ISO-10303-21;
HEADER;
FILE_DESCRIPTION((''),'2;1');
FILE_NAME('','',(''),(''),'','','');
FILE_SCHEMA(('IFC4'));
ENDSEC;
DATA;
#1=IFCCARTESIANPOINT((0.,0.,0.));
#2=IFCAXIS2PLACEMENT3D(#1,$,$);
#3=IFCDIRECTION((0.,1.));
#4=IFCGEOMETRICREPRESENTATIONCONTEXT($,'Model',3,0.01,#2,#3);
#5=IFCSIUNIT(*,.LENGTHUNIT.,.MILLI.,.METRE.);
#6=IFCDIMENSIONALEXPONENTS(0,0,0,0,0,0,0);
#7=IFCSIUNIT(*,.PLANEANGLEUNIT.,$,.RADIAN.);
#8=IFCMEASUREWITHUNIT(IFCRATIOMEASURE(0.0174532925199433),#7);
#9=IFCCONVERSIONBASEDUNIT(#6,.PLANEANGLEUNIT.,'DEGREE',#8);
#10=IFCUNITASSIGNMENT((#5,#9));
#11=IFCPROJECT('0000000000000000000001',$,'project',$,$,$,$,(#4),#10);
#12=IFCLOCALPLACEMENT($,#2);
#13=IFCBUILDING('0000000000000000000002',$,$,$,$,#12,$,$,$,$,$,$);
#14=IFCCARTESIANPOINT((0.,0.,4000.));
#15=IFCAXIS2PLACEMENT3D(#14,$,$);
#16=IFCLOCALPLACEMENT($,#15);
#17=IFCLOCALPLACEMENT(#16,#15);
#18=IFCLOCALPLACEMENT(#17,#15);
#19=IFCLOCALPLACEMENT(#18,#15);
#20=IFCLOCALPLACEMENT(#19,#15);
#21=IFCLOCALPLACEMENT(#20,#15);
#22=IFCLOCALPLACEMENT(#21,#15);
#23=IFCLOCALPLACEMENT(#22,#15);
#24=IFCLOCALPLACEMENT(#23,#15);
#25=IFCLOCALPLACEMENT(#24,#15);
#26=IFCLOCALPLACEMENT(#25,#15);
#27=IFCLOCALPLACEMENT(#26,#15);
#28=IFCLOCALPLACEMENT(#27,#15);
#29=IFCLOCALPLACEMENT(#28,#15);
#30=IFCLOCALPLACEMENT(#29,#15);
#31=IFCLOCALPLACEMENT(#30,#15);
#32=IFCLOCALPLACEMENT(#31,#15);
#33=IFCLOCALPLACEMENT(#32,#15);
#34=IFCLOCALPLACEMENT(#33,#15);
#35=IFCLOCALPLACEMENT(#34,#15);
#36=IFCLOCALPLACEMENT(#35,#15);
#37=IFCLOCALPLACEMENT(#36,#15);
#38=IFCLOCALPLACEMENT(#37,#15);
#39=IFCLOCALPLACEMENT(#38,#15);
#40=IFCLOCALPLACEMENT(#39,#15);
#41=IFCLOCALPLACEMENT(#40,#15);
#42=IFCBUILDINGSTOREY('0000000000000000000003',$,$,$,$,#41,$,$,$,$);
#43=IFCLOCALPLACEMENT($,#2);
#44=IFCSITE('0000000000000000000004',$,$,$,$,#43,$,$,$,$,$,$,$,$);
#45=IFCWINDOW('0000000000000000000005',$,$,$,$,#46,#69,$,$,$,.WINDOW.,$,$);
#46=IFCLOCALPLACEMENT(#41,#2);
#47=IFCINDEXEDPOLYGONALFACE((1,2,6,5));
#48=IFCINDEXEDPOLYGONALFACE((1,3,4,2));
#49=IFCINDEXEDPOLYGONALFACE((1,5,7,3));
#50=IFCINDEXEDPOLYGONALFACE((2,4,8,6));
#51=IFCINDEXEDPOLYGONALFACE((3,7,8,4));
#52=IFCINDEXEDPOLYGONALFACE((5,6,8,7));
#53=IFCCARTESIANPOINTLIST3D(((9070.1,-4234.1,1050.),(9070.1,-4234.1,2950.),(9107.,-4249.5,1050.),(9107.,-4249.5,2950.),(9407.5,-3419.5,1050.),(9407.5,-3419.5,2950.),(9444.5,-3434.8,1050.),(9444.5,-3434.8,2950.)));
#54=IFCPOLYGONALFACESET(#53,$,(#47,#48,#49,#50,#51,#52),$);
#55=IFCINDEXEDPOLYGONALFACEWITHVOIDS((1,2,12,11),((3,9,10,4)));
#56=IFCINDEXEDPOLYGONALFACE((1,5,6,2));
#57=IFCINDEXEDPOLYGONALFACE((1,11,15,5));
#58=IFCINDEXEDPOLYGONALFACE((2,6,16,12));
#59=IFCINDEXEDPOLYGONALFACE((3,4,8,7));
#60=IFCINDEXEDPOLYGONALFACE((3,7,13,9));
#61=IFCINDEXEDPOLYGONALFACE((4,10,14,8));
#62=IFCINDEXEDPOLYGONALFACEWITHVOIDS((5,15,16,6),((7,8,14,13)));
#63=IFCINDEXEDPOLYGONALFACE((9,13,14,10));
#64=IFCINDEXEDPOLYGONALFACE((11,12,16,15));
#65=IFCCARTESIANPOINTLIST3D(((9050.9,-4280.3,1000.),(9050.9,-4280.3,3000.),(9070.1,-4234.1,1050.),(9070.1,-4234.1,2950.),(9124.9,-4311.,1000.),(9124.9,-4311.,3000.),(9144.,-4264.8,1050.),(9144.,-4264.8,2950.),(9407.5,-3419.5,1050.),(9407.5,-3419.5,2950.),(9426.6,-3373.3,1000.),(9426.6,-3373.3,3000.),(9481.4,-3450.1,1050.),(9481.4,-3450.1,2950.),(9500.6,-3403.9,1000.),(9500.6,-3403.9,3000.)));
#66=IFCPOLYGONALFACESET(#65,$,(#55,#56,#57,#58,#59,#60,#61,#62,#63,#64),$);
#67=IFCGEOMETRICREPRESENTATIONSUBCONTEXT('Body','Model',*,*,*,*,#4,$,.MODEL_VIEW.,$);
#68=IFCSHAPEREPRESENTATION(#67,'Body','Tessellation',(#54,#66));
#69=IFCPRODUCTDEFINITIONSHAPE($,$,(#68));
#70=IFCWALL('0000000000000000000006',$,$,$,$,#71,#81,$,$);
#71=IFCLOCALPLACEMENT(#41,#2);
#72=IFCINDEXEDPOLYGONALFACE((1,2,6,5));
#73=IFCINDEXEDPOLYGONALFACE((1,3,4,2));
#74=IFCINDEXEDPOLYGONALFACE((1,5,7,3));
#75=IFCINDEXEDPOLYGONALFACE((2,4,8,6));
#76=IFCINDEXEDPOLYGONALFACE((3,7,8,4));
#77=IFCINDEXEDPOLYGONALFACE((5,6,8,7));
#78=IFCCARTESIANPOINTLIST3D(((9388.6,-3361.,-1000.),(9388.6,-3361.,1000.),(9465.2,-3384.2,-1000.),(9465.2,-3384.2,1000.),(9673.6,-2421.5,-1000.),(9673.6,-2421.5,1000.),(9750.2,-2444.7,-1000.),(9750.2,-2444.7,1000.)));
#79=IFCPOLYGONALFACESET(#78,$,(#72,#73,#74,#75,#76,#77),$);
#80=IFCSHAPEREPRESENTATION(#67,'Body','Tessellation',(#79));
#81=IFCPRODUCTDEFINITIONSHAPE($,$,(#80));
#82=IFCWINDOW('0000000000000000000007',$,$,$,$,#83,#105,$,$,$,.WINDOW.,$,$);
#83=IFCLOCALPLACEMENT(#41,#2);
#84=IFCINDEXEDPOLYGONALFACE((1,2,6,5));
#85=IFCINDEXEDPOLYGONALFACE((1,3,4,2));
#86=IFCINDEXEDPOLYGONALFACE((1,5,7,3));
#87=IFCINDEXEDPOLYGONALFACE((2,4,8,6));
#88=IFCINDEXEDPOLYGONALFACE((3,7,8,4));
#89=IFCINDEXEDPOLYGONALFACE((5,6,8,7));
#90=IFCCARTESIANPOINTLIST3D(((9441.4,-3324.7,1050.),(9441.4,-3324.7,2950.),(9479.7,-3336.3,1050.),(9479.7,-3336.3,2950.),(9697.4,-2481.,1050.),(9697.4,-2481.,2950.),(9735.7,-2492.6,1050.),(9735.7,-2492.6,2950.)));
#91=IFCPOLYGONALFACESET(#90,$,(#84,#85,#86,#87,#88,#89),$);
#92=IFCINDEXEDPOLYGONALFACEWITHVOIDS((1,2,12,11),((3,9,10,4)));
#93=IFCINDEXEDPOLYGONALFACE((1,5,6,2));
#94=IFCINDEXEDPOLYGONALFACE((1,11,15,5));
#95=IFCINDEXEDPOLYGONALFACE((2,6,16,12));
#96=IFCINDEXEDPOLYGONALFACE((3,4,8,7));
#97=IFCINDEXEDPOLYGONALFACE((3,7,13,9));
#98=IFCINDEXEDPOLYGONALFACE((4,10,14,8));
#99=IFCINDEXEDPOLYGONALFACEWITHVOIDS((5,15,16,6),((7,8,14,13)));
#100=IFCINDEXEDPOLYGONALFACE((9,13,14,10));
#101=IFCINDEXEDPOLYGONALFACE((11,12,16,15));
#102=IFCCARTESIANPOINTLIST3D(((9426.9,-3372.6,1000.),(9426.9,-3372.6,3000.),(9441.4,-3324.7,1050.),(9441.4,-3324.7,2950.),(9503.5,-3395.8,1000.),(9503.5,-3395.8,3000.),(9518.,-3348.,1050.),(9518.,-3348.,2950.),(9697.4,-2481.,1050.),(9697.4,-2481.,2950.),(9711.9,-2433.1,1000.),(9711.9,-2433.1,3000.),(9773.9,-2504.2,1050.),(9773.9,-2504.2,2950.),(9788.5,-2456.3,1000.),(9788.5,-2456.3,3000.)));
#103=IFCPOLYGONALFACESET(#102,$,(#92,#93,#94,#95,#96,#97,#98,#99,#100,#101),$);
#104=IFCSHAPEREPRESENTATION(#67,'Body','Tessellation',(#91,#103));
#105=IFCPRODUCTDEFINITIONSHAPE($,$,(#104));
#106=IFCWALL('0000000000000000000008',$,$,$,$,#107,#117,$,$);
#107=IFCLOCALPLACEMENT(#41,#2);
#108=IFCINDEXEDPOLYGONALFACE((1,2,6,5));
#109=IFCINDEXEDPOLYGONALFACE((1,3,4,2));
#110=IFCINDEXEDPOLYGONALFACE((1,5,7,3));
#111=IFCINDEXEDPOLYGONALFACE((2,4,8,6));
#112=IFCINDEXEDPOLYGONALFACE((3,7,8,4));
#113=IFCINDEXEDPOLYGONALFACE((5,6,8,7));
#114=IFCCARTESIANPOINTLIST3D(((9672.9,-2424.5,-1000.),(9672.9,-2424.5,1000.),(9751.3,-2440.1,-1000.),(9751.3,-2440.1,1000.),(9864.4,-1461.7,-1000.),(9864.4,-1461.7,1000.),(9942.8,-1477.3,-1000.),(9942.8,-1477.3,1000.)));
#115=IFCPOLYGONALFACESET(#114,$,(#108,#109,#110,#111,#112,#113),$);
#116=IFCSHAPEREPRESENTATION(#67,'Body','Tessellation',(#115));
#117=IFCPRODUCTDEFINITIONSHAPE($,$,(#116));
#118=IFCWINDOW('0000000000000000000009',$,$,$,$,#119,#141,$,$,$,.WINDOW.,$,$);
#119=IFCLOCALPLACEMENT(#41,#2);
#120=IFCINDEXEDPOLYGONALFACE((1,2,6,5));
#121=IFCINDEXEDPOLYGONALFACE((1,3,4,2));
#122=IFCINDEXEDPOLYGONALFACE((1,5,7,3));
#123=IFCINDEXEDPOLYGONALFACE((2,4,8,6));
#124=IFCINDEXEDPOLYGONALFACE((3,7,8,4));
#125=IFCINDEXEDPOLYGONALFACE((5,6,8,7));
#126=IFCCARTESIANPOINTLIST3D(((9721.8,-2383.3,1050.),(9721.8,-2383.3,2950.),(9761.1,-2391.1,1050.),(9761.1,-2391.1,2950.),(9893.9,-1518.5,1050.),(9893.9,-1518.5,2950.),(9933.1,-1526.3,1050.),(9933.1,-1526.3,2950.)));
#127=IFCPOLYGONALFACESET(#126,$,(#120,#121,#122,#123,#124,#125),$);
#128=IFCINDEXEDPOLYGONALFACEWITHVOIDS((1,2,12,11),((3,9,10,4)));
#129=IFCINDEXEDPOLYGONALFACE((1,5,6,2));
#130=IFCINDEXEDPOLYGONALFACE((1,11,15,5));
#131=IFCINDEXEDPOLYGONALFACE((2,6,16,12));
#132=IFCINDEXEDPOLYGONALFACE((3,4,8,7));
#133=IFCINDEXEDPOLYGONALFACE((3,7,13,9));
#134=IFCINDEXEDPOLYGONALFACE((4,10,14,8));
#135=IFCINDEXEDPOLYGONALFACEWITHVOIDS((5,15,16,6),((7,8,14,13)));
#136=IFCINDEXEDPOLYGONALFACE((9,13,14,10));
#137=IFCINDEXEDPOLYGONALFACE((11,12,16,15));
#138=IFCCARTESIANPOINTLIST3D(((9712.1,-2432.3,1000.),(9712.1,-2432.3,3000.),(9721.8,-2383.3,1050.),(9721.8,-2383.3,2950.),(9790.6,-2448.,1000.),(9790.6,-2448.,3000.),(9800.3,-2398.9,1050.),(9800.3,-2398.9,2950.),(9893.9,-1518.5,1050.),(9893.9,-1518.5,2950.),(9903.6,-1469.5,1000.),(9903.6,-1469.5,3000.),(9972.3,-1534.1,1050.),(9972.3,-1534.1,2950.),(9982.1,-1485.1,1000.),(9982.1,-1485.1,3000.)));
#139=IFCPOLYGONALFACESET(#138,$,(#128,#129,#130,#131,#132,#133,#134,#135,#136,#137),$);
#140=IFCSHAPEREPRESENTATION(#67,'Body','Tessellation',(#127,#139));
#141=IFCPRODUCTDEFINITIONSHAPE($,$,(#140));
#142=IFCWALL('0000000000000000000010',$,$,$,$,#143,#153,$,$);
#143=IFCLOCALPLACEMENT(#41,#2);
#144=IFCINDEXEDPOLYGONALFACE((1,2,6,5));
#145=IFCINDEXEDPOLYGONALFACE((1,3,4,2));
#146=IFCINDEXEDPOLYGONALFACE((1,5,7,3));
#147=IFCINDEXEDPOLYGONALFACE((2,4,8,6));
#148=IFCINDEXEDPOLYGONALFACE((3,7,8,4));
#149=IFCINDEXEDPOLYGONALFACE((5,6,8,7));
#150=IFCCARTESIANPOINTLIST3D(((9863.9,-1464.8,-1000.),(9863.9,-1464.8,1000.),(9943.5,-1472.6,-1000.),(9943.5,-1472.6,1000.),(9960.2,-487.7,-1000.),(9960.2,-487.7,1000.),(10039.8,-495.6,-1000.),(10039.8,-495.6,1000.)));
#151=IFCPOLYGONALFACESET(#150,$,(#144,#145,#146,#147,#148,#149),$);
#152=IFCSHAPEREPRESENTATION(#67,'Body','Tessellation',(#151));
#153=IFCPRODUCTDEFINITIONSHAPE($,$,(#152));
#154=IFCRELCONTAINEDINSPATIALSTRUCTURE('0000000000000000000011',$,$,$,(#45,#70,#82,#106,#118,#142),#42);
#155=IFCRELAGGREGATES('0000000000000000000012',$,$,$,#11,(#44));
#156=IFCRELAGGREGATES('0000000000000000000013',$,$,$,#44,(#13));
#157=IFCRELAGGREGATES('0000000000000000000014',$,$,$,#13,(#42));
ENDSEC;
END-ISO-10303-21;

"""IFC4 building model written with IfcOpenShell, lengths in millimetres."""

from ifc_helpers import new_model, entity, si_unit, converted_unit, direction, frame, origin, origin_2d, place, context, subcontext, project, spatial, rectangle, extrude, element, save


model = new_model("IFC4")

# Units and contexts
model_context = context("Model", 3, precision=0.01, world=origin(), true_north=direction((0.0, 1.0)))
body_context = subcontext(model_context, "Body", "Model", "MODEL_VIEW")
ifc_project = project(units=[si_unit("LENGTHUNIT", "METRE", prefix="MILLI"), converted_unit("PLANEANGLEUNIT", "DEGREE", entity("IfcRatioMeasure", 0.0174532925199433), si_unit("PLANEANGLEUNIT", "RADIAN"), dimensions=[0, 0, 0, 0, 0, 0, 0])], contexts=[model_context])

# Site, building, storey
site_placement = place(None, origin())
site = spatial("IfcSite", under=ifc_project, at=site_placement)
building_placement = place(None, origin())
building = spatial("IfcBuilding", under=site, at=building_placement)
placement_1 = place(None, frame((0.0, 0.0, 4000.0)))
placement_2 = place(placement_1, frame((0.0, 0.0, 4000.0)))
placement_3 = place(placement_2, frame((0.0, 0.0, 4000.0)))
placement_4 = place(placement_3, frame((0.0, 0.0, 4000.0)))
placement_5 = place(placement_4, frame((0.0, 0.0, 4000.0)))
placement_6 = place(placement_5, frame((0.0, 0.0, 4000.0)))
placement_7 = place(placement_6, frame((0.0, 0.0, 4000.0)))
placement_8 = place(placement_7, frame((0.0, 0.0, 4000.0)))
placement_9 = place(placement_8, frame((0.0, 0.0, 4000.0)))
placement_10 = place(placement_9, frame((0.0, 0.0, 4000.0)))
placement_11 = place(placement_10, frame((0.0, 0.0, 4000.0)))
placement_12 = place(placement_11, frame((0.0, 0.0, 4000.0)))
placement_13 = place(placement_12, frame((0.0, 0.0, 4000.0)))
placement_14 = place(placement_13, frame((0.0, 0.0, 4000.0)))
placement_15 = place(placement_14, frame((0.0, 0.0, 4000.0)))
placement_16 = place(placement_15, frame((0.0, 0.0, 4000.0)))
placement_17 = place(placement_16, frame((0.0, 0.0, 4000.0)))
placement_18 = place(placement_17, frame((0.0, 0.0, 4000.0)))
placement_19 = place(placement_18, frame((0.0, 0.0, 4000.0)))
placement_20 = place(placement_19, frame((0.0, 0.0, 4000.0)))
placement_21 = place(placement_20, frame((0.0, 0.0, 4000.0)))
placement_22 = place(placement_21, frame((0.0, 0.0, 4000.0)))
placement_23 = place(placement_22, frame((0.0, 0.0, 4000.0)))
placement_24 = place(placement_23, frame((0.0, 0.0, 4000.0)))
placement_25 = place(placement_24, frame((0.0, 0.0, 4000.0)))
storey_placement = place(placement_25, frame((0.0, 0.0, 4000.0)))
storey = spatial("IfcBuildingStorey", under=building, at=storey_placement)

# Shared definitions
cartesian_point_1 = entity("IfcCartesianPoint", [-440.9, -950.0])
shared_polyline = entity("IfcPolyline", [cartesian_point_1, entity("IfcCartesianPoint", [-440.9, 950.0]), entity("IfcCartesianPoint", [-440.9, 950.0]), entity("IfcCartesianPoint", [440.9, 950.0]), entity("IfcCartesianPoint", [440.9, 950.0]), entity("IfcCartesianPoint", [440.9, -950.0]), entity("IfcCartesianPoint", [440.9, -950.0]), entity("IfcCartesianPoint", [-440.9, -950.0]), cartesian_point_1])

# Window
window_1_placement = place(storey_placement, frame((9238.8, -3826.8, 2000.0), z_axis=(0.0, 0.0, 1.0), x_axis=(3826.834186, 9238.795382, 0.0)))
cartesian_point_2 = entity("IfcCartesianPoint", [-490.9, -1000.0])
element("IfcWindow", 1, at=window_1_placement, inside=storey, PredefinedType="WINDOW", context=body_context, shape_type="SweptSolid", body=[
    entity("IfcExtrudedAreaSolid", entity("IfcArbitraryClosedProfileDef", "AREA", None, shared_polyline), entity("IfcAxis2Placement3D", entity("IfcCartesianPoint", [0.0, 0.0, 0.0]), entity("IfcDirection", [0.0, -1.0, 0.0]), entity("IfcDirection", [1.0, 0.0, 0.0])), entity("IfcDirection", [0.0, 0.0, 1.0]), 40.0),
    entity("IfcExtrudedAreaSolid", entity("IfcArbitraryProfileDefWithVoids", "AREA", None, entity("IfcPolyline", [cartesian_point_2, entity("IfcCartesianPoint", [-490.9, 1000.0]), entity("IfcCartesianPoint", [-490.9, 1000.0]), entity("IfcCartesianPoint", [490.9, 1000.0]), entity("IfcCartesianPoint", [490.9, 1000.0]), entity("IfcCartesianPoint", [490.9, -1000.0]), entity("IfcCartesianPoint", [490.9, -1000.0]), entity("IfcCartesianPoint", [-490.9, -1000.0]), cartesian_point_2]), [shared_polyline]), entity("IfcAxis2Placement3D", entity("IfcCartesianPoint", [0.0, 0.0, 0.0]), entity("IfcDirection", [0.0, -1.0, 0.0]), entity("IfcDirection", [1.0, 0.0, 0.0])), entity("IfcDirection", [0.0, 0.0, 1.0]), 80.0),
])

# Wall
wall_1_placement = place(storey_placement, frame((9569.4, -2902.8, -1000.0), z_axis=(0.0, 0.0, 1.0), x_axis=(2902.848529, 9569.402825, 0.0)))
element("IfcWall", 2, at=wall_1_placement, inside=storey, context=body_context, shape_type="SweptSolid", body=[
    extrude(rectangle(XDim=981.7, YDim=80.0, at=origin_2d()), origin(), (0.0, 0.0, 1.0), 2000.0),
])

# Window
window_2_placement = place(storey_placement, frame((9569.4, -2902.8, 2000.0), z_axis=(0.0, 0.0, 1.0), x_axis=(2902.848529, 9569.402825, 0.0)))
cartesian_point_3 = entity("IfcCartesianPoint", [-490.9, -1000.0])
element("IfcWindow", 3, at=window_2_placement, inside=storey, PredefinedType="WINDOW", context=body_context, shape_type="SweptSolid", body=[
    entity("IfcExtrudedAreaSolid", entity("IfcArbitraryClosedProfileDef", "AREA", None, shared_polyline), entity("IfcAxis2Placement3D", entity("IfcCartesianPoint", [0.0, 0.0, 0.0]), entity("IfcDirection", [0.0, -1.0, 0.0]), entity("IfcDirection", [1.0, 0.0, 0.0])), entity("IfcDirection", [0.0, 0.0, 1.0]), 40.0),
    entity("IfcExtrudedAreaSolid", entity("IfcArbitraryProfileDefWithVoids", "AREA", None, entity("IfcPolyline", [cartesian_point_3, entity("IfcCartesianPoint", [-490.9, 1000.0]), entity("IfcCartesianPoint", [-490.9, 1000.0]), entity("IfcCartesianPoint", [490.9, 1000.0]), entity("IfcCartesianPoint", [490.9, 1000.0]), entity("IfcCartesianPoint", [490.9, -1000.0]), entity("IfcCartesianPoint", [490.9, -1000.0]), entity("IfcCartesianPoint", [-490.9, -1000.0]), cartesian_point_3]), [shared_polyline]), entity("IfcAxis2Placement3D", entity("IfcCartesianPoint", [0.0, 0.0, 0.0]), entity("IfcDirection", [0.0, -1.0, 0.0]), entity("IfcDirection", [1.0, 0.0, 0.0])), entity("IfcDirection", [0.0, 0.0, 1.0]), 80.0),
])

# Wall
wall_2_placement = place(storey_placement, frame((9807.9, -1950.9, -1000.0), z_axis=(0.0, 0.0, 1.0), x_axis=(1950.90229, 9807.852989, 0.0)))
element("IfcWall", 4, at=wall_2_placement, inside=storey, context=body_context, shape_type="SweptSolid", body=[
    extrude(rectangle(XDim=981.7, YDim=80.0, at=origin_2d()), origin(), (0.0, 0.0, 1.0), 2000.0),
])

# Window
window_3_placement = place(storey_placement, frame((9807.9, -1950.9, 2000.0), z_axis=(0.0, 0.0, 1.0), x_axis=(1950.90229, 9807.852989, 0.0)))
cartesian_point_4 = entity("IfcCartesianPoint", [-490.9, -1000.0])
element("IfcWindow", 5, at=window_3_placement, inside=storey, PredefinedType="WINDOW", context=body_context, shape_type="SweptSolid", body=[
    entity("IfcExtrudedAreaSolid", entity("IfcArbitraryClosedProfileDef", "AREA", None, shared_polyline), entity("IfcAxis2Placement3D", entity("IfcCartesianPoint", [0.0, 0.0, 0.0]), entity("IfcDirection", [0.0, -1.0, 0.0]), entity("IfcDirection", [1.0, 0.0, 0.0])), entity("IfcDirection", [0.0, 0.0, 1.0]), 40.0),
    entity("IfcExtrudedAreaSolid", entity("IfcArbitraryProfileDefWithVoids", "AREA", None, entity("IfcPolyline", [cartesian_point_4, entity("IfcCartesianPoint", [-490.9, 1000.0]), entity("IfcCartesianPoint", [-490.9, 1000.0]), entity("IfcCartesianPoint", [490.9, 1000.0]), entity("IfcCartesianPoint", [490.9, 1000.0]), entity("IfcCartesianPoint", [490.9, -1000.0]), entity("IfcCartesianPoint", [490.9, -1000.0]), entity("IfcCartesianPoint", [-490.9, -1000.0]), cartesian_point_4]), [shared_polyline]), entity("IfcAxis2Placement3D", entity("IfcCartesianPoint", [0.0, 0.0, 0.0]), entity("IfcDirection", [0.0, -1.0, 0.0]), entity("IfcDirection", [1.0, 0.0, 0.0])), entity("IfcDirection", [0.0, 0.0, 1.0]), 80.0),
])

# Wall
wall_3_placement = place(storey_placement, frame((9951.8, -980.2, -1000.0), z_axis=(0.0, 0.0, 1.0), x_axis=(980.172434, 9951.847165, 0.0)))
element("IfcWall", 6, at=wall_3_placement, inside=storey, context=body_context, shape_type="SweptSolid", body=[
    extrude(rectangle(XDim=981.7, YDim=80.0, at=origin_2d()), origin(), (0.0, 0.0, 1.0), 2000.0),
])

save(model, "model.ifc")
